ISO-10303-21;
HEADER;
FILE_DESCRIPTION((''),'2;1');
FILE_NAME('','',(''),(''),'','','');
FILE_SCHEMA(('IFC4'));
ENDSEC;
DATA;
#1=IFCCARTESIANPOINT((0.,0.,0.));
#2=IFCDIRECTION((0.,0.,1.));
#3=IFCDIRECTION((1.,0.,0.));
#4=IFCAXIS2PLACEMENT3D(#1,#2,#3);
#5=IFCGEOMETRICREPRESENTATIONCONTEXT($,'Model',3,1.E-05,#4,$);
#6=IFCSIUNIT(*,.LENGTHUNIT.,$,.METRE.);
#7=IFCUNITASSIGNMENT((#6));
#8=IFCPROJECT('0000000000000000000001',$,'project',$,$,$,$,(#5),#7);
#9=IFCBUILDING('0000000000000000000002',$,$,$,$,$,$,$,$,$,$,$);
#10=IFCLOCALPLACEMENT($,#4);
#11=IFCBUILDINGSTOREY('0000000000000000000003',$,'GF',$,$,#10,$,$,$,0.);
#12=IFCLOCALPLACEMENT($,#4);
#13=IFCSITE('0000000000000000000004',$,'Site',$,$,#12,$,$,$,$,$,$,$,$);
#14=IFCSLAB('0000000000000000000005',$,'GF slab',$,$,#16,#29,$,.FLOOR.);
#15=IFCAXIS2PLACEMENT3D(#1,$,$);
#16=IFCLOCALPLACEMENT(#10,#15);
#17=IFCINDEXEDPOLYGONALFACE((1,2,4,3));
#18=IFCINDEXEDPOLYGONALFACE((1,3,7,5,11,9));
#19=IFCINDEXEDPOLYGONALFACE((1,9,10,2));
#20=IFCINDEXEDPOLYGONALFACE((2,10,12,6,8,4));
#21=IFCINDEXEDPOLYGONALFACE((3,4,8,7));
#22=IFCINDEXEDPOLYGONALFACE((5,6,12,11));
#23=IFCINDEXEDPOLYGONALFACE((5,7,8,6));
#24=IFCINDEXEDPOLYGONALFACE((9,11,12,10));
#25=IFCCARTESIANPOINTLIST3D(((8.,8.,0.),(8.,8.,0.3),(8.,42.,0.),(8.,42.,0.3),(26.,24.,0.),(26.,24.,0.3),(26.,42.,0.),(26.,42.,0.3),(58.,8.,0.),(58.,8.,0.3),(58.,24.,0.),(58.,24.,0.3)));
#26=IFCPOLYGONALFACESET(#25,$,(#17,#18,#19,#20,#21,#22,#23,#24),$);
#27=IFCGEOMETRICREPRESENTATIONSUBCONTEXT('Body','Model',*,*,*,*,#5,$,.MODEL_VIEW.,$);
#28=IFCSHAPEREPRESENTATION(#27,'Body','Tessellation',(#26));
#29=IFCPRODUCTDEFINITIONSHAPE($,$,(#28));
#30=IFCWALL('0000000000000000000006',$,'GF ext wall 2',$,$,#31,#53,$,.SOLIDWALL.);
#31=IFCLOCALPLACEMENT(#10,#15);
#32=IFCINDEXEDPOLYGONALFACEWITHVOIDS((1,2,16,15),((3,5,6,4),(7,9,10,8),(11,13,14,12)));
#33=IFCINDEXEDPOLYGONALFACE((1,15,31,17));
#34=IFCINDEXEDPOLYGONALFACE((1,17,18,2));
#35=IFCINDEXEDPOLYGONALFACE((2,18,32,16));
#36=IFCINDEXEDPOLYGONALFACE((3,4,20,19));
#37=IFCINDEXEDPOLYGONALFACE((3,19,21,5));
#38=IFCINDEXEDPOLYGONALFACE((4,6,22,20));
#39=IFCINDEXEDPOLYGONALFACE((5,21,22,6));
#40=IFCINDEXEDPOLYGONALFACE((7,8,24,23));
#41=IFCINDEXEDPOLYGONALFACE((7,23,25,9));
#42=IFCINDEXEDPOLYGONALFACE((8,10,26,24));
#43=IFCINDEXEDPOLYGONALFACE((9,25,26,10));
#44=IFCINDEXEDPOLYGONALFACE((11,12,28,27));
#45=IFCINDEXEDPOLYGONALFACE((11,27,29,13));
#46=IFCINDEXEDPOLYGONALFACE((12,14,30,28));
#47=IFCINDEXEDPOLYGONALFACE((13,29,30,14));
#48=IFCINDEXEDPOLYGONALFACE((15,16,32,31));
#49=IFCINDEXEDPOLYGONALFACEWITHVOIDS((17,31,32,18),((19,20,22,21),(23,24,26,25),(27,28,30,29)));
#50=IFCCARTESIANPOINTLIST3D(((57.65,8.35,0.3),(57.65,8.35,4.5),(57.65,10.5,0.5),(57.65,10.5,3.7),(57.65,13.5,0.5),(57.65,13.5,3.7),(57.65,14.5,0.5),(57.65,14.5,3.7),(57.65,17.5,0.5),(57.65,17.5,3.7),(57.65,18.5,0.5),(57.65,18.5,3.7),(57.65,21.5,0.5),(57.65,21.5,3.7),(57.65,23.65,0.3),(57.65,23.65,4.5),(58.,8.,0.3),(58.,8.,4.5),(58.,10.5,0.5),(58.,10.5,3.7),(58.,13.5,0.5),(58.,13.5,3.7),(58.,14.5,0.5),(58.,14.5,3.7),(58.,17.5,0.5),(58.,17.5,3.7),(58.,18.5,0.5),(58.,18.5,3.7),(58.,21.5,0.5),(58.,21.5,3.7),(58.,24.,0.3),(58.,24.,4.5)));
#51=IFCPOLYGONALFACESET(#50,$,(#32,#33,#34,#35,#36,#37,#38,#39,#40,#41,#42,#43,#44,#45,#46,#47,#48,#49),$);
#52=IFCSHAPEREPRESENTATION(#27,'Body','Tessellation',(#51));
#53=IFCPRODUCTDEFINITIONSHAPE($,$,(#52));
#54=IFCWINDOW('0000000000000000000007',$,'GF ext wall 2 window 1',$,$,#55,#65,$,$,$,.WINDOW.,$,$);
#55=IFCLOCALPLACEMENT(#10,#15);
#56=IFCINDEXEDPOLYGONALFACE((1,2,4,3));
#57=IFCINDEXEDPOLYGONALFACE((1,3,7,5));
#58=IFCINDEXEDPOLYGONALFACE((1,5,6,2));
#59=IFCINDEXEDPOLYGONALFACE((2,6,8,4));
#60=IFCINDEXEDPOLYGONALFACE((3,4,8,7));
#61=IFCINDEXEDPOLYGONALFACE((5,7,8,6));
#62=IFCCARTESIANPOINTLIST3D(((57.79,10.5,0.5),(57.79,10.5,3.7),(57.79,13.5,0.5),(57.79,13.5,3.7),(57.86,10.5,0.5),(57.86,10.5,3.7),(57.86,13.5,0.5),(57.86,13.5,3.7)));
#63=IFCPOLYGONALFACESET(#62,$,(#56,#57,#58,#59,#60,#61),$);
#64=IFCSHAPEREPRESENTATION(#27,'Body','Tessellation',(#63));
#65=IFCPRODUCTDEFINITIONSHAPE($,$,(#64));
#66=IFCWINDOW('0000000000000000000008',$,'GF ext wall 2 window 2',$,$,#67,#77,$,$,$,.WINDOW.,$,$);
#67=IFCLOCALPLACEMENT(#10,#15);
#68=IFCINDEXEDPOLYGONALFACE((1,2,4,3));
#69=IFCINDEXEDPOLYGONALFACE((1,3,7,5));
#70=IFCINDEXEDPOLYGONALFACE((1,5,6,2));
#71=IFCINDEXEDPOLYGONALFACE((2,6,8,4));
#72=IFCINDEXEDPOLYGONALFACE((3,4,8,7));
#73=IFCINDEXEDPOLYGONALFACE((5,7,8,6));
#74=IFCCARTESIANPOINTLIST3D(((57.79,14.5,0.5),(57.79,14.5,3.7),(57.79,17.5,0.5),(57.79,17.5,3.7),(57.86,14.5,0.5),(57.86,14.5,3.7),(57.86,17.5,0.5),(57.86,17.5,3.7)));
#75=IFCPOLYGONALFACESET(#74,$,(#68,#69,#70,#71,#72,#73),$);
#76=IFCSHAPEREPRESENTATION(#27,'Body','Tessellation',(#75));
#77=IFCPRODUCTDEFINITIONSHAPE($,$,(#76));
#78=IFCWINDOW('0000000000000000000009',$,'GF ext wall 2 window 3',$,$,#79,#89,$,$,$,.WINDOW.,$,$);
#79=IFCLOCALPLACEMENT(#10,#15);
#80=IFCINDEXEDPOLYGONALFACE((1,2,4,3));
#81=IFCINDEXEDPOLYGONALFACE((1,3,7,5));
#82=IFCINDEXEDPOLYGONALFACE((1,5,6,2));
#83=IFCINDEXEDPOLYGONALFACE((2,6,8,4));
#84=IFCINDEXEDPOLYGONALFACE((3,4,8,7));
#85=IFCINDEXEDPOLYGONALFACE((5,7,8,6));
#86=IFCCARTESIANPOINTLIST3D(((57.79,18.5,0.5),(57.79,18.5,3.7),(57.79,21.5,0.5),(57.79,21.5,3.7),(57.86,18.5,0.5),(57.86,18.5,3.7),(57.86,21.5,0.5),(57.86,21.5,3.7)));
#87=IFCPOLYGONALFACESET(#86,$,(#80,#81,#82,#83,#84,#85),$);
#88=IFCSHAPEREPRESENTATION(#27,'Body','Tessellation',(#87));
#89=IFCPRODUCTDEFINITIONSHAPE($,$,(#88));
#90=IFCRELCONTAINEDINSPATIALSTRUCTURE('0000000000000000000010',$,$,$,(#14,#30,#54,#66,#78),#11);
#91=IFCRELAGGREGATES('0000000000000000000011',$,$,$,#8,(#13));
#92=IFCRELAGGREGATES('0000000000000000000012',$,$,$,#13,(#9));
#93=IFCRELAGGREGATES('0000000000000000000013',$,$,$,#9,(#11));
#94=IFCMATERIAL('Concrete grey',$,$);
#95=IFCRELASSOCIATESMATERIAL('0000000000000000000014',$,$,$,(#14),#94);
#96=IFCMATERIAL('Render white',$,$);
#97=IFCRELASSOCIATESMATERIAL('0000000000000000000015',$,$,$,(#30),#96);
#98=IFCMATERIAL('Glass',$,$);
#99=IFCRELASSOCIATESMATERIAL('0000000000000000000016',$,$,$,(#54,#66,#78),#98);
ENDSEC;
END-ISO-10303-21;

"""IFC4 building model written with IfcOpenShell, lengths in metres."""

from ifc_helpers import new_model, si_unit, frame, origin_with_axes, place, context, subcontext, project, spatial, polyline, outline, extrude, material, element, fill, save


model = new_model("IFC4")

# Units and contexts
model_context = context("Model", 3, precision=1e-05, world=origin_with_axes())
body_context = subcontext(model_context, "Body", "Model", "MODEL_VIEW")
ifc_project = project(units=[si_unit("LENGTHUNIT", "METRE")], contexts=[model_context])

# Site, building, storey
site_placement = place(None, origin_with_axes())
site = spatial("IfcSite", under=ifc_project, at=site_placement, Name="Site")
building = spatial("IfcBuilding", under=site)
storey_placement = place(None, origin_with_axes())
storey = spatial("IfcBuildingStorey", under=building, at=storey_placement, Name="GF", Elevation=0.0)

# Slab
ifc_material_1 = material(Name="Concrete grey")
slab_placement = place(storey_placement, origin_with_axes())
element("IfcSlab", 1, at=slab_placement, inside=storey, material=ifc_material_1, Name="GF slab", PredefinedType="FLOOR", context=body_context, shape_type="SweptSolid", body=[
    extrude(outline(polyline([(8.0, 8.0), (58.0, 8.0), (58.0, 24.0), (26.0, 24.0), (26.0, 42.0), (8.0, 42.0), (8.0, 8.0)])), origin_with_axes(), (0.0, 0.0, 1.0), 0.3),
])

# Wall, openings, windows
ifc_material_2 = material(Name="Render white")
ifc_material_3 = material(Name="Glass")
wall_1_placement = place(storey_placement, origin_with_axes())
wall_1 = element("IfcWall", 2, at=wall_1_placement, inside=storey, material=ifc_material_2, Name="GF ext wall 2", PredefinedType="SOLIDWALL", context=body_context, shape_type="SweptSolid", body=[
    extrude(outline(polyline([(58.0, 8.0), (58.0, 24.0), (57.65, 23.65), (57.65, 8.35), (58.0, 8.0)])), frame((0.0, 0.0, 0.3), z_axis=(0.0, 0.0, 1.0), x_axis=(1.0, 0.0, 0.0)), (0.0, 0.0, 1.0), 4.2),
])
opening_1_placement = place(wall_1_placement, origin_with_axes())
opening_1 = element("IfcOpeningElement", 3, at=opening_1_placement, cuts=wall_1, context=body_context, shape_type="SweptSolid", body=[
    extrude(outline(polyline([(58.05, 10.5), (58.05, 13.5), (57.6, 13.5), (57.6, 10.5), (58.05, 10.5)])), frame((0.0, 0.0, 0.5), z_axis=(0.0, 0.0, 1.0), x_axis=(1.0, 0.0, 0.0)), (0.0, 0.0, 1.0), 3.2),
])
opening_2_placement = place(wall_1_placement, origin_with_axes())
opening_2 = element("IfcOpeningElement", 4, at=opening_2_placement, cuts=wall_1, context=body_context, shape_type="SweptSolid", body=[
    extrude(outline(polyline([(58.05, 14.5), (58.05, 17.5), (57.6, 17.5), (57.6, 14.5), (58.05, 14.5)])), frame((0.0, 0.0, 0.5), z_axis=(0.0, 0.0, 1.0), x_axis=(1.0, 0.0, 0.0)), (0.0, 0.0, 1.0), 3.2),
])
opening_3_placement = place(wall_1_placement, origin_with_axes())
opening_3 = element("IfcOpeningElement", 5, at=opening_3_placement, cuts=wall_1, context=body_context, shape_type="SweptSolid", body=[
    extrude(outline(polyline([(58.05, 18.5), (58.05, 21.5), (57.6, 21.5), (57.6, 18.5), (58.05, 18.5)])), frame((0.0, 0.0, 0.5), z_axis=(0.0, 0.0, 1.0), x_axis=(1.0, 0.0, 0.0)), (0.0, 0.0, 1.0), 3.2),
])
window_1_placement = place(storey_placement, origin_with_axes())
window_1 = element("IfcWindow", 6, at=window_1_placement, inside=storey, material=ifc_material_3, Name="GF ext wall 2 window 1", PredefinedType="WINDOW", context=body_context, shape_type="SweptSolid", body=[
    extrude(outline(polyline([(57.86, 10.5), (57.86, 13.5), (57.79, 13.5), (57.79, 10.5), (57.86, 10.5)])), frame((0.0, 0.0, 0.5), z_axis=(0.0, 0.0, 1.0), x_axis=(1.0, 0.0, 0.0)), (0.0, 0.0, 1.0), 3.2),
])
fill(opening_1, window_1)
window_2_placement = place(storey_placement, origin_with_axes())
window_2 = element("IfcWindow", 7, at=window_2_placement, inside=storey, material=ifc_material_3, Name="GF ext wall 2 window 2", PredefinedType="WINDOW", context=body_context, shape_type="SweptSolid", body=[
    extrude(outline(polyline([(57.86, 14.5), (57.86, 17.5), (57.79, 17.5), (57.79, 14.5), (57.86, 14.5)])), frame((0.0, 0.0, 0.5), z_axis=(0.0, 0.0, 1.0), x_axis=(1.0, 0.0, 0.0)), (0.0, 0.0, 1.0), 3.2),
])
fill(opening_2, window_2)
window_3_placement = place(storey_placement, origin_with_axes())
window_3 = element("IfcWindow", 8, at=window_3_placement, inside=storey, material=ifc_material_3, Name="GF ext wall 2 window 3", PredefinedType="WINDOW", context=body_context, shape_type="SweptSolid", body=[
    extrude(outline(polyline([(57.86, 18.5), (57.86, 21.5), (57.79, 21.5), (57.79, 18.5), (57.86, 18.5)])), frame((0.0, 0.0, 0.5), z_axis=(0.0, 0.0, 1.0), x_axis=(1.0, 0.0, 0.0)), (0.0, 0.0, 1.0), 3.2),
])
fill(opening_3, window_3)

save(model, "model.ifc")
